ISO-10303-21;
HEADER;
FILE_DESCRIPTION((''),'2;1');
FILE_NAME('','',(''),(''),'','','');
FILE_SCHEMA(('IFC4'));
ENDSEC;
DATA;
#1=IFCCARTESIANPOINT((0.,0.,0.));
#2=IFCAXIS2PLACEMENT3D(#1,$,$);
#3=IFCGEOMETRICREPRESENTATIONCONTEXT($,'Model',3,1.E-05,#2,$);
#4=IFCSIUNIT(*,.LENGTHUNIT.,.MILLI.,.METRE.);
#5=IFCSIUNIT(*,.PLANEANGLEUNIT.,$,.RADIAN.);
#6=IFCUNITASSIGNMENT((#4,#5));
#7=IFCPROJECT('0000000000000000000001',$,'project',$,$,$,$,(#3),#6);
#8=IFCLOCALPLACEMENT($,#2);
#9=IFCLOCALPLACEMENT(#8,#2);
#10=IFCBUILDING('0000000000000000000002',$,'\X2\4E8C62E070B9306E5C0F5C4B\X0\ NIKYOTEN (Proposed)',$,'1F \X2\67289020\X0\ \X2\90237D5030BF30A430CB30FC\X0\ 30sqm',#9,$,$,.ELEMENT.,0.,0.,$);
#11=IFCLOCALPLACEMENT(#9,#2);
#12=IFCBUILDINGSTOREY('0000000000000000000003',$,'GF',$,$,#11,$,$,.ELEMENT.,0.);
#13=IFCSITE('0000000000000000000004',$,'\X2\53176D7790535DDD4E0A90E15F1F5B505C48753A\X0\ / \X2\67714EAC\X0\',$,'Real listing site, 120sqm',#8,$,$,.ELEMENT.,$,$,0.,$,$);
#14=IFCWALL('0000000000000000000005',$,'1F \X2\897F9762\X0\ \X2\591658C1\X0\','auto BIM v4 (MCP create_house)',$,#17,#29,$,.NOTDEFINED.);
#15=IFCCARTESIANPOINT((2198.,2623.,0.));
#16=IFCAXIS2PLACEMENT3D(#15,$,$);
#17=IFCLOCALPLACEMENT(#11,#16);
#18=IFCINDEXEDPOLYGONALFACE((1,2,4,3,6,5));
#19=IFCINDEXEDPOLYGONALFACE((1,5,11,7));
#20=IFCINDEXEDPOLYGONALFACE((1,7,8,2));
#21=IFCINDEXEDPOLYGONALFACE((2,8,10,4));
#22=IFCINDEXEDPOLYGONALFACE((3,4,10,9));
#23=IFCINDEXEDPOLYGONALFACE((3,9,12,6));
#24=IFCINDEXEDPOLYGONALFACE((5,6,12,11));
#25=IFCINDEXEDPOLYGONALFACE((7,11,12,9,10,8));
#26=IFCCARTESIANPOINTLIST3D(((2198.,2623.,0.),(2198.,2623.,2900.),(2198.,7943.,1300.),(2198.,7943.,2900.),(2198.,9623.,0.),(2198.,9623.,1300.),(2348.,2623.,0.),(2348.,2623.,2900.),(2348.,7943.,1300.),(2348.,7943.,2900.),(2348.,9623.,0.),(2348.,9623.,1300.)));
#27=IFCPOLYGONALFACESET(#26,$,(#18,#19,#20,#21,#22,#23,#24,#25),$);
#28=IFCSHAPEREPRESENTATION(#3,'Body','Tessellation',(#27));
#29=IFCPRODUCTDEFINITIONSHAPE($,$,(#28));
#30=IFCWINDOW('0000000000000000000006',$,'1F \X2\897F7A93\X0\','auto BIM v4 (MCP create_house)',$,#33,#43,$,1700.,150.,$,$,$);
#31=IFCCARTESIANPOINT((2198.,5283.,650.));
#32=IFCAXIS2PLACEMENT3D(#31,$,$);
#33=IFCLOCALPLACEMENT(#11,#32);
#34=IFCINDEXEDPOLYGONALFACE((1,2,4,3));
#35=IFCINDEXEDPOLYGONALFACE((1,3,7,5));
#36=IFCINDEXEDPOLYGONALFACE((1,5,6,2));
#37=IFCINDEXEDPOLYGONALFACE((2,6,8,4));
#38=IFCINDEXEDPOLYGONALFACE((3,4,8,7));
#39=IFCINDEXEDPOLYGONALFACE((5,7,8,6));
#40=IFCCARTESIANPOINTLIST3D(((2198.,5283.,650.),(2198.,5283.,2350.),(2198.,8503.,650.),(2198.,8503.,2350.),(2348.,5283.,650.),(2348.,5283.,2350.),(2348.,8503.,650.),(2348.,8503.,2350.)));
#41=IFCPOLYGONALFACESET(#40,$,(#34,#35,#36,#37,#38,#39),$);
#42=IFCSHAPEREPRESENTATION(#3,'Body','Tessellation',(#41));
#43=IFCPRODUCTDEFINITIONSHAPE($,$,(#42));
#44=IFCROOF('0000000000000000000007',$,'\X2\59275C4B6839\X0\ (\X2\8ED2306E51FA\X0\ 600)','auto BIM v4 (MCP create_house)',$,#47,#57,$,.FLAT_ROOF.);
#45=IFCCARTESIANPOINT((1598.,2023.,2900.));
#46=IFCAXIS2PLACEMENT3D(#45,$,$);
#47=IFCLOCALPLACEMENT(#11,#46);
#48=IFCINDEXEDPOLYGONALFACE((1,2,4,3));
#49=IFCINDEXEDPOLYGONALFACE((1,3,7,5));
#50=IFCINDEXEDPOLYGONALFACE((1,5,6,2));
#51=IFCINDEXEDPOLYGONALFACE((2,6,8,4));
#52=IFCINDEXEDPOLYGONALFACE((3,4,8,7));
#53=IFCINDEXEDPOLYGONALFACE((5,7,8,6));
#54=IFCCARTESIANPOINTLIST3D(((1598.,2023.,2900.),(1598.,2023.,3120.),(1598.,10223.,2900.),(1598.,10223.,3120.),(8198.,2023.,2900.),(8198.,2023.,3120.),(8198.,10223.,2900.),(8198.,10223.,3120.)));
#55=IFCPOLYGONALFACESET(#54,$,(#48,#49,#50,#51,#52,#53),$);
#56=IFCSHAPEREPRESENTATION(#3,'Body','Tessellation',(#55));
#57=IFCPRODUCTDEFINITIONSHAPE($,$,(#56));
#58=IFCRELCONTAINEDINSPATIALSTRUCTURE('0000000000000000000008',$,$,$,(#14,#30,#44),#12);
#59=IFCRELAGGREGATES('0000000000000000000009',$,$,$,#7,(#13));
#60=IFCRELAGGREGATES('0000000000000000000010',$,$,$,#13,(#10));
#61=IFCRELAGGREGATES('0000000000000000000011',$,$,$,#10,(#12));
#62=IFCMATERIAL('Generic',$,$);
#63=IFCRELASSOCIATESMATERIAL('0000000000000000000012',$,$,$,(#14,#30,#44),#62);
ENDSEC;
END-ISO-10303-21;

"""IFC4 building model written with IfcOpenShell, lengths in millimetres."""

from ifc_helpers import new_model, si_unit, frame, frame_2d, origin, place, context, project, spatial, rectangle, extrude, material, element, fill, save


model = new_model("IFC4")

# Units and contexts
model_context = context("Model", 3, precision=1e-05, world=origin())
ifc_project = project(units=[si_unit("LENGTHUNIT", "METRE", prefix="MILLI"), si_unit("PLANEANGLEUNIT", "RADIAN")], contexts=[model_context])

# Site, building, storey
site_placement = place(None, origin())
site = spatial("IfcSite", under=ifc_project, at=site_placement, Name="北海道川上郡弟子屈町 / 東京", ObjectType="Real listing site, 120sqm", CompositionType="ELEMENT", RefElevation=0.0)
building_placement = place(site_placement, origin())
building = spatial("IfcBuilding", under=site, at=building_placement, Name="二拠点の小屋 NIKYOTEN (Proposed)", ObjectType="1F 木造 連結タイニー 30sqm", CompositionType="ELEMENT", ElevationOfRefHeight=0.0, ElevationOfTerrain=0.0)
storey_placement = place(building_placement, origin())
storey = spatial("IfcBuildingStorey", under=building, at=storey_placement, Name="GF", CompositionType="ELEMENT", Elevation=0.0)

# Shared definitions
ifc_material = material(Name="Generic")

# Wall, opening, window
wall_1_placement = place(storey_placement, frame((2198.0, 2623.0, 0.0)))
wall_1 = element("IfcWall", 1, at=wall_1_placement, inside=storey, material=ifc_material, Name="1F 西面 外壁", Description="auto BIM v4 (MCP create_house)", PredefinedType="NOTDEFINED", context=model_context, shape_type="SweptSolid", body=[
    extrude(rectangle(XDim=150.0, YDim=7000.0, at=frame_2d((75.0, 3500.0))), frame((2198.0, 2623.0, 0.0)), (0.0, 0.0, 1.0), 2900.0),
])
opening_1_placement = place(storey_placement, frame((2198.0, 5283.0, 650.0)))
opening_1 = element("IfcOpeningElement", 2, at=opening_1_placement, cuts=wall_1, PredefinedType="NOTDEFINED", context=model_context, shape_type="SweptSolid", body=[
    extrude(rectangle(XDim=150.0, YDim=3220.0, at=frame_2d((75.0, 1610.0))), frame((2198.0, 5283.0, 650.0)), (0.0, 0.0, 1.0), 1700.0),
])
window_1_placement = place(storey_placement, frame((2198.0, 5283.0, 650.0)))
window_1 = element("IfcWindow", 3, at=window_1_placement, inside=storey, material=ifc_material, Name="1F 西窓", Description="auto BIM v4 (MCP create_house)", OverallHeight=1700.0, OverallWidth=150.0, context=model_context, shape_type="SweptSolid", body=[
    extrude(rectangle(XDim=150.0, YDim=3220.0, at=frame_2d((75.0, 1610.0))), frame((2198.0, 5283.0, 650.0)), (0.0, 0.0, 1.0), 1700.0),
])
fill(opening_1, window_1)

# Roof
roof_placement = place(storey_placement, frame((1598.0, 2023.0, 2900.0)))
element("IfcRoof", 4, at=roof_placement, inside=storey, material=ifc_material, Name="大屋根 (軒の出 600)", Description="auto BIM v4 (MCP create_house)", PredefinedType="FLAT_ROOF", context=model_context, shape_type="SweptSolid", body=[
    extrude(rectangle(XDim=6600.0, YDim=8200.0, at=frame_2d((3300.0, 4100.0))), frame((1598.0, 2023.0, 2900.0)), (0.0, 0.0, 1.0), 220.0),
])

save(model, "model.ifc")
